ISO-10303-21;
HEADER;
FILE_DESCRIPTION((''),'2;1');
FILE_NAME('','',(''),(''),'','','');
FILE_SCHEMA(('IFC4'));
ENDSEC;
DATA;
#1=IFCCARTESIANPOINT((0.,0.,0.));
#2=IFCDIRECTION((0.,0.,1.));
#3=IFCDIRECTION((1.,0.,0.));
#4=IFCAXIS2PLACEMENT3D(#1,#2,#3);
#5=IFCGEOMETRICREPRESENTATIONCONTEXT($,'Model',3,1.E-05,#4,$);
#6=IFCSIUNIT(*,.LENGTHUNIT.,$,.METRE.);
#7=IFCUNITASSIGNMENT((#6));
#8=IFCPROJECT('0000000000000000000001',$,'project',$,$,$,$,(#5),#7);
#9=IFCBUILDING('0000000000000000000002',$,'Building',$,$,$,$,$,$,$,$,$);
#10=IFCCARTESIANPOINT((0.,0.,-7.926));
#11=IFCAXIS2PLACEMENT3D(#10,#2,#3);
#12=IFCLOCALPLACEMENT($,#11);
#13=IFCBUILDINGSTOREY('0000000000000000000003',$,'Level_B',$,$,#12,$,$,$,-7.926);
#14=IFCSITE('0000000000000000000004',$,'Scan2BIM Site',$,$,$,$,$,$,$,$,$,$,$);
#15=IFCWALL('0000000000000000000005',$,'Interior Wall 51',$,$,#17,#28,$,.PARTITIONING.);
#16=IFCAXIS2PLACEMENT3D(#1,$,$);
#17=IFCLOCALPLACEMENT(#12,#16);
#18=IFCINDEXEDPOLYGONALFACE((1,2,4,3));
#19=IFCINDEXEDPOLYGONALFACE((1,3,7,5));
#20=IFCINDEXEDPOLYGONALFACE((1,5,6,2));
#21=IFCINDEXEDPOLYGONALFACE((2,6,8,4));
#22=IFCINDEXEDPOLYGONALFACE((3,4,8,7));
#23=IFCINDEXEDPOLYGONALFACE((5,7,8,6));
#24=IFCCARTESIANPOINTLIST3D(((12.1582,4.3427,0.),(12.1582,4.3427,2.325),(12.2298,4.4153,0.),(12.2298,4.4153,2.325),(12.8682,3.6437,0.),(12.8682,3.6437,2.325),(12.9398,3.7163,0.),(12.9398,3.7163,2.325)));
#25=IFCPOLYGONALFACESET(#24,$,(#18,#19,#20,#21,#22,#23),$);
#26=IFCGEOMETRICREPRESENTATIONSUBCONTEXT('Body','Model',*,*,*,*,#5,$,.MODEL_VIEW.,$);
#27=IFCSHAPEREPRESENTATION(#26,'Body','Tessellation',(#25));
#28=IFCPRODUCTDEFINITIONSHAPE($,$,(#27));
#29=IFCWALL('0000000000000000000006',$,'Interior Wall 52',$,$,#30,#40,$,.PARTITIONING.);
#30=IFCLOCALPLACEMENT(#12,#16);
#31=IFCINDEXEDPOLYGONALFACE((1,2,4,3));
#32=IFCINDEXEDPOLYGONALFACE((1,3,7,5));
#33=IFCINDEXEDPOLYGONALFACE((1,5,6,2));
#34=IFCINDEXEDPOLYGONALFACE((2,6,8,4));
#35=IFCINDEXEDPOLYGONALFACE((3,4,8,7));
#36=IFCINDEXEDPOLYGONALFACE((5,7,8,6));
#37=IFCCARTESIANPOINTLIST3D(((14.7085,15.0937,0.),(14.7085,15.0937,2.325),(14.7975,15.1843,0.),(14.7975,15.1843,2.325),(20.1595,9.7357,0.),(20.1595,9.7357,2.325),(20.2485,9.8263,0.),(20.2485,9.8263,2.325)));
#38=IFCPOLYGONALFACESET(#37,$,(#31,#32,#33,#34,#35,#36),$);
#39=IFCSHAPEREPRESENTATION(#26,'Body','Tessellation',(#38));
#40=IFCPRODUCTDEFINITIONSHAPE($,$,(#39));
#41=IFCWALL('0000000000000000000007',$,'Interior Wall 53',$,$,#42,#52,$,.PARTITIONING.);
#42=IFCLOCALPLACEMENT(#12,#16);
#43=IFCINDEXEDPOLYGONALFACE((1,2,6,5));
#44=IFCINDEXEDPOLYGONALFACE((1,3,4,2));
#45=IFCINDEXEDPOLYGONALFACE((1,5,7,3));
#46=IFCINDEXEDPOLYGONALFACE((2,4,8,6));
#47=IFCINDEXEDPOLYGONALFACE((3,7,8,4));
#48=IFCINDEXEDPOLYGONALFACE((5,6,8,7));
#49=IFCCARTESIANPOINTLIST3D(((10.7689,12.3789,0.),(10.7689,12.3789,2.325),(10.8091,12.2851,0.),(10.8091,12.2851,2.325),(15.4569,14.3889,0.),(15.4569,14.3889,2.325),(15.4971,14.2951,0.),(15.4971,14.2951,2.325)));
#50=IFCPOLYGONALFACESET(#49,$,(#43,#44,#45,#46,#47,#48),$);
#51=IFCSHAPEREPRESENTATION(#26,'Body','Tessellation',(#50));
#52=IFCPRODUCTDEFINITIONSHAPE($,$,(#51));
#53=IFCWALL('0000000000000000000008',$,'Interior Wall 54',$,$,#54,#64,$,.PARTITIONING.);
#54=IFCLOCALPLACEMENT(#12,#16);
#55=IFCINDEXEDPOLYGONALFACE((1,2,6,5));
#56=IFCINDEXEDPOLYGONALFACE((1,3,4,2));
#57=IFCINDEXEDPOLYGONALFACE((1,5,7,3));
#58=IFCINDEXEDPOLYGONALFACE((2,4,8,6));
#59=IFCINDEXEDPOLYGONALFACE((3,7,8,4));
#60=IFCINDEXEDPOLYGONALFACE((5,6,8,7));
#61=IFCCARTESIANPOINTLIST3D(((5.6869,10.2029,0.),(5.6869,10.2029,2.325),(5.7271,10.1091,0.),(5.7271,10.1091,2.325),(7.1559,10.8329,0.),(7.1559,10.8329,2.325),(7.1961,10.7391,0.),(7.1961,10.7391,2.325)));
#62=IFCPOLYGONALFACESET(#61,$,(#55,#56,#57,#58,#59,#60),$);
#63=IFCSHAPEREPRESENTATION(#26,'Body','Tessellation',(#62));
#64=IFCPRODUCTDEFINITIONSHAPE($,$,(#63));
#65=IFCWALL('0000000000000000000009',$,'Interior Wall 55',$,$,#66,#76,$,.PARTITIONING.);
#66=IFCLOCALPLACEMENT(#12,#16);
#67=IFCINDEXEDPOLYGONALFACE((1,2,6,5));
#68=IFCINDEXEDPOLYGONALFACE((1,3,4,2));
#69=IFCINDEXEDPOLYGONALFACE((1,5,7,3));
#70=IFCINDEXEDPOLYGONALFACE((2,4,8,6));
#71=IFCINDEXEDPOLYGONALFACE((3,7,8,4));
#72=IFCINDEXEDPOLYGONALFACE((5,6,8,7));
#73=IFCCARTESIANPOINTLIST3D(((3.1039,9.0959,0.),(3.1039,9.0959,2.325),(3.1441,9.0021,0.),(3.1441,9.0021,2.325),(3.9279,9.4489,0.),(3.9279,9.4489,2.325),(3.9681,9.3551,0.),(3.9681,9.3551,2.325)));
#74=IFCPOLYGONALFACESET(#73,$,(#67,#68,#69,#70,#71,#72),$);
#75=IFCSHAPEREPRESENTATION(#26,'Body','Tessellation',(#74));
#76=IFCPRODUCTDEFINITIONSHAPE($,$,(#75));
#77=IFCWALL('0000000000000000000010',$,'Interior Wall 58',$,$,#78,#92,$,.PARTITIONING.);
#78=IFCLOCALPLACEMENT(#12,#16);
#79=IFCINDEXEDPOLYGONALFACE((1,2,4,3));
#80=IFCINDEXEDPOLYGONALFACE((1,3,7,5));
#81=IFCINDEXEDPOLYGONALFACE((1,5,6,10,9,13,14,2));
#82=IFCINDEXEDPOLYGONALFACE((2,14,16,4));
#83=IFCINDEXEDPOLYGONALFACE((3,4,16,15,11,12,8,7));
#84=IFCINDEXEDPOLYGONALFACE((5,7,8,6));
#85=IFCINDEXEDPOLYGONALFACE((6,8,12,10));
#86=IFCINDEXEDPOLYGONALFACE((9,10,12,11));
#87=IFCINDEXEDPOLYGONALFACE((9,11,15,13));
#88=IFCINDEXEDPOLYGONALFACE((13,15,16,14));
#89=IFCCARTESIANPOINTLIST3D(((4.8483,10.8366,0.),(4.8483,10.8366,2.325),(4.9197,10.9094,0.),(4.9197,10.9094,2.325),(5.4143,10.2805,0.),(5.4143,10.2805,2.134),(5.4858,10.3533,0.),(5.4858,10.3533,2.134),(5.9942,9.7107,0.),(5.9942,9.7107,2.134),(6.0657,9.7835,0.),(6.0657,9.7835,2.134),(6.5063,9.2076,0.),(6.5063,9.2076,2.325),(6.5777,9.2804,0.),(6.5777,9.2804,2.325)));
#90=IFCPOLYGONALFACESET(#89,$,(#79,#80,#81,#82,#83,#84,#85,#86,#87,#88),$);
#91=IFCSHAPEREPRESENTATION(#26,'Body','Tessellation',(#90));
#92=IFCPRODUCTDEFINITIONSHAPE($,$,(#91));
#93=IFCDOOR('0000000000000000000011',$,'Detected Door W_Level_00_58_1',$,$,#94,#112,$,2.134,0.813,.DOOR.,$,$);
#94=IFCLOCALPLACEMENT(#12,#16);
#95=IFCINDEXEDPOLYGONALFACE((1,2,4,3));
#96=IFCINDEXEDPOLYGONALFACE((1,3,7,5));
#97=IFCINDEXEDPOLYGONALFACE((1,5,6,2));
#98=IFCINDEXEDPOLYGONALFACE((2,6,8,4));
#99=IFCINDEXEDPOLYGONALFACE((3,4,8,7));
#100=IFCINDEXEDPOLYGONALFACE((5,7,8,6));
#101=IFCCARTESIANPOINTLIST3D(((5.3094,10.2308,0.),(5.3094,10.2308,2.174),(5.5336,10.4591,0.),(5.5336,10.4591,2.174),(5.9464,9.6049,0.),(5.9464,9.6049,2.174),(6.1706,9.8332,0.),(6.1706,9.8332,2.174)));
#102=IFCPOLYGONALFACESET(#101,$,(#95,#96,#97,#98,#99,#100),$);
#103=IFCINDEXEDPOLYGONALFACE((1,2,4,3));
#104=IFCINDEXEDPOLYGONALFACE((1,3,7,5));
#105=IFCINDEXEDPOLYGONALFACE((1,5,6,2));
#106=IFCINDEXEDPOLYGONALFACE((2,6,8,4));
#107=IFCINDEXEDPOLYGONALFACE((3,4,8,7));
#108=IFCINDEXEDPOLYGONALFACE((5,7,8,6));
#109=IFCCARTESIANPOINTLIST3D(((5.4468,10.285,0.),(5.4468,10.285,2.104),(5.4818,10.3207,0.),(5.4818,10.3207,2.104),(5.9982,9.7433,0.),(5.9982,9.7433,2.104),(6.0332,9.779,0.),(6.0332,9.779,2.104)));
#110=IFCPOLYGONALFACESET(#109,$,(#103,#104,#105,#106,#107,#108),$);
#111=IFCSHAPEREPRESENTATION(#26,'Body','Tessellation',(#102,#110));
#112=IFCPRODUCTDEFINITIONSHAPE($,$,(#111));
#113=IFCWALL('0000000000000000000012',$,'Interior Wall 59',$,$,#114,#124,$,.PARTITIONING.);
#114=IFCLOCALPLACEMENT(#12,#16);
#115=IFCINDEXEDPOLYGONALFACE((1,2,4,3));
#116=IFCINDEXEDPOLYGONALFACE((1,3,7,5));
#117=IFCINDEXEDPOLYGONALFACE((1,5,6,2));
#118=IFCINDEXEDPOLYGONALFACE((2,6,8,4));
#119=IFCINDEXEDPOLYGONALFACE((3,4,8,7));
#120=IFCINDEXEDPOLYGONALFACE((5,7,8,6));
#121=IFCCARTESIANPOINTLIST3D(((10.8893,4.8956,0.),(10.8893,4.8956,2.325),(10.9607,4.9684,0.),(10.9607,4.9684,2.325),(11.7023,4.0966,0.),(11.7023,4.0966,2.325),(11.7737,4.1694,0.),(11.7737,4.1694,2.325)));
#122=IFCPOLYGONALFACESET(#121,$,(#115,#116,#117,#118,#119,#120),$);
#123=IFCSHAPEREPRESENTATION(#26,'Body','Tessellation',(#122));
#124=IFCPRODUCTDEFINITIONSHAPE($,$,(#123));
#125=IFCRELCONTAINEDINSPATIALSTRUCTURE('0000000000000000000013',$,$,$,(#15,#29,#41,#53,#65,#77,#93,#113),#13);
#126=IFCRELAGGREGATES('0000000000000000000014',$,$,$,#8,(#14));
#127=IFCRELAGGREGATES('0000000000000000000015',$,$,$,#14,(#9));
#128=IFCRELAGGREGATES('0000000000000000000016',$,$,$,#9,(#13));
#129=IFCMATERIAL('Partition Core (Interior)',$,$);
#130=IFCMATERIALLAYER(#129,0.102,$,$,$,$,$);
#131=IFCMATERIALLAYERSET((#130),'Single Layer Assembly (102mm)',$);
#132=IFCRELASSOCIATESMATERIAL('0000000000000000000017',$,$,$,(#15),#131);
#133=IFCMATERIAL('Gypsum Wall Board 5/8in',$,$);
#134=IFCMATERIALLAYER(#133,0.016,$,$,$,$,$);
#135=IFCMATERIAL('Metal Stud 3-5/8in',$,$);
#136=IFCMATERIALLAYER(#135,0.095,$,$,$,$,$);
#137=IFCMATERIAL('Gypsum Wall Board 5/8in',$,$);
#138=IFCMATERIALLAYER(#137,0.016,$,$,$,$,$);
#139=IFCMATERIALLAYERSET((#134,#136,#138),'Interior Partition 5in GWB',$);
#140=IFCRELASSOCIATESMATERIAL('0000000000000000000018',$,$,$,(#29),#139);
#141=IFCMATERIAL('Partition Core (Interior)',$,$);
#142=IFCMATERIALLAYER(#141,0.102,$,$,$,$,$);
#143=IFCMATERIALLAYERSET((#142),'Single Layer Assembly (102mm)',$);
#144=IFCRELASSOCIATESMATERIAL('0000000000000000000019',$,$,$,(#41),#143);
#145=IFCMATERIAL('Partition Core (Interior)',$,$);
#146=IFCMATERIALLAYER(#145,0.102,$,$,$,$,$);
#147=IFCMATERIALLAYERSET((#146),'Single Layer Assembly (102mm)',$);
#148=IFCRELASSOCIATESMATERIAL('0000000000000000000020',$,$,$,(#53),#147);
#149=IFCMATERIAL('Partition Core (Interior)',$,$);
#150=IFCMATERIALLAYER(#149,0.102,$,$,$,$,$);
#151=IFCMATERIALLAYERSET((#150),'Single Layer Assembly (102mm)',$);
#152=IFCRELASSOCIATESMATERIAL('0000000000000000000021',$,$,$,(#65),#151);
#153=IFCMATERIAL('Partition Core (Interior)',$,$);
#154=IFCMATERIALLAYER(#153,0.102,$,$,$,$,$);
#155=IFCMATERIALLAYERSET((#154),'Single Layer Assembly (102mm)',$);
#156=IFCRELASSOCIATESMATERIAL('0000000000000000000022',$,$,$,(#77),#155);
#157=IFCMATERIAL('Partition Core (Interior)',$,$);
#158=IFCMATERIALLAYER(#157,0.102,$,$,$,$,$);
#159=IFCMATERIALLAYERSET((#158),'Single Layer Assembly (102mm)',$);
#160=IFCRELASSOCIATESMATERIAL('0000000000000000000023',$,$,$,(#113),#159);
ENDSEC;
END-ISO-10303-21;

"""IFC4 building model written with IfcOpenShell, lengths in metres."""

from ifc_helpers import new_model, si_unit, frame, origin, origin_with_axes, place, context, subcontext, project, spatial, rectangle, extrude, material, layer, layer_set, element, fill, save


model = new_model("IFC4")

# Units and contexts
model_context = context("Model", 3, precision=1e-05, world=origin_with_axes())
body_context = subcontext(model_context, "Body", "Model", "MODEL_VIEW")
ifc_project = project(units=[si_unit("LENGTHUNIT", "METRE")], contexts=[model_context])

# Site, building, storey
site = spatial("IfcSite", under=ifc_project, Name="Scan2BIM Site")
building = spatial("IfcBuilding", under=site, Name="Building")
storey_placement = place(None, frame((0.0, 0.0, -7.926), z_axis=(0.0, 0.0, 1.0), x_axis=(1.0, 0.0, 0.0)))
storey = spatial("IfcBuildingStorey", under=building, at=storey_placement, Name="Level_B", Elevation=-7.926)

# Walls
ifc_material_1 = material(Name="Partition Core (Interior)")
ifc_layer_1 = layer(ifc_material_1, 0.102)
ifc_layer_set_1 = layer_set([ifc_layer_1], Name="Single Layer Assembly (102mm)")
wall_1_placement = place(storey_placement, frame((12.549, 4.0295, 0.0), z_axis=(0.0, 0.0, 1.0), x_axis=(0.712605, -0.701565, 0.0)))
element("IfcWall", 1, at=wall_1_placement, inside=storey, material=ifc_layer_set_1, Name="Interior Wall 51", PredefinedType="PARTITIONING", context=body_context, shape_type="SweptSolid", body=[
    extrude(rectangle(XDim=0.9963, YDim=0.102), origin(), (0.0, 0.0, 1.0), 2.325),
])
ifc_material_2 = material(Name="Gypsum Wall Board 5/8in")
ifc_layer_2 = layer(ifc_material_2, 0.016)
ifc_material_3 = material(Name="Metal Stud 3-5/8in")
ifc_layer_3 = layer(ifc_material_3, 0.095)
ifc_material_4 = material(Name="Gypsum Wall Board 5/8in")
ifc_layer_4 = layer(ifc_material_4, 0.016)
ifc_layer_set_2 = layer_set([ifc_layer_2, ifc_layer_3, ifc_layer_4], Name="Interior Partition 5in GWB")
wall_2_placement = place(storey_placement, frame((17.4785, 12.46, 0.0), z_axis=(0.0, 0.0, 1.0), x_axis=(-0.713164, 0.700997, 0.0)))
element("IfcWall", 2, at=wall_2_placement, inside=storey, material=ifc_layer_set_2, Name="Interior Wall 52", PredefinedType="PARTITIONING", context=body_context, shape_type="SweptSolid", body=[
    extrude(rectangle(XDim=7.6434, YDim=0.127), origin(), (0.0, 0.0, 1.0), 2.325),
])
ifc_material_5 = material(Name="Partition Core (Interior)")
ifc_layer_5 = layer(ifc_material_5, 0.102)
ifc_layer_set_3 = layer_set([ifc_layer_5], Name="Single Layer Assembly (102mm)")
wall_3_placement = place(storey_placement, frame((13.133, 13.337, 0.0), z_axis=(0.0, 0.0, 1.0), x_axis=(-0.919084, -0.394061, 0.0)))
element("IfcWall", 3, at=wall_3_placement, inside=storey, material=ifc_layer_set_3, Name="Interior Wall 53", PredefinedType="PARTITIONING", context=body_context, shape_type="SweptSolid", body=[
    extrude(rectangle(XDim=5.1007, YDim=0.102), origin(), (0.0, 0.0, 1.0), 2.325),
])
ifc_material_6 = material(Name="Partition Core (Interior)")
ifc_layer_6 = layer(ifc_material_6, 0.102)
ifc_layer_set_4 = layer_set([ifc_layer_6], Name="Single Layer Assembly (102mm)")
wall_4_placement = place(storey_placement, frame((6.4415, 10.471, 0.0), z_axis=(0.0, 0.0, 1.0), x_axis=(-0.919048, -0.394146, 0.0)))
element("IfcWall", 4, at=wall_4_placement, inside=storey, material=ifc_layer_set_4, Name="Interior Wall 54", PredefinedType="PARTITIONING", context=body_context, shape_type="SweptSolid", body=[
    extrude(rectangle(XDim=1.5984, YDim=0.102), origin(), (0.0, 0.0, 1.0), 2.325),
])
ifc_material_7 = material(Name="Partition Core (Interior)")
ifc_layer_7 = layer(ifc_material_7, 0.102)
ifc_layer_set_5 = layer_set([ifc_layer_7], Name="Single Layer Assembly (102mm)")
wall_5_placement = place(storey_placement, frame((3.536, 9.2255, 0.0), z_axis=(0.0, 0.0, 1.0), x_axis=(-0.919203, -0.393785, 0.0)))
element("IfcWall", 5, at=wall_5_placement, inside=storey, material=ifc_layer_set_5, Name="Interior Wall 55", PredefinedType="PARTITIONING", context=body_context, shape_type="SweptSolid", body=[
    extrude(rectangle(XDim=0.8964, YDim=0.102), origin(), (0.0, 0.0, 1.0), 2.325),
])

# Wall, opening, door
ifc_material_8 = material(Name="Partition Core (Interior)")
ifc_layer_8 = layer(ifc_material_8, 0.102)
ifc_layer_set_6 = layer_set([ifc_layer_8], Name="Single Layer Assembly (102mm)")
wall_6_placement = place(storey_placement, frame((5.713, 10.0585, 0.0), z_axis=(0.0, 0.0, 1.0), x_axis=(0.713318, -0.700841, 0.0)))
wall_6 = element("IfcWall", 6, at=wall_6_placement, inside=storey, material=ifc_layer_set_6, Name="Interior Wall 58", PredefinedType="PARTITIONING", context=body_context, shape_type="SweptSolid", body=[
    extrude(rectangle(XDim=2.3244, YDim=0.102), origin(), (0.0, 0.0, 1.0), 2.325),
])
opening_1_placement = place(None, frame((5.74, 10.032, -7.926), z_axis=(0.0, 0.0, 1.0), x_axis=(0.713318, -0.700841, 0.0)))
opening_1 = element("IfcOpeningElement", 7, at=opening_1_placement, cuts=wall_6, PredefinedType="OPENING", context=body_context, shape_type="SweptSolid", body=[
    extrude(rectangle(XDim=0.813, YDim=0.202), origin(), (0.0, 0.0, 1.0), 2.134),
])
door_1_placement = place(opening_1_placement, frame((0.0, 0.0, 0.0), z_axis=(0.0, 0.0, 1.0), x_axis=(1.0, 0.0, 0.0)))
door_1 = element("IfcDoor", 8, at=door_1_placement, inside=storey, Name="Detected Door W_Level_00_58_1", OverallHeight=2.134, OverallWidth=0.813, PredefinedType="DOOR", context=body_context, shape_type="SweptSolid", body=[
    extrude(rectangle(XDim=0.893, YDim=0.32), origin(), (0.0, 0.0, 1.0), 2.174),
    extrude(rectangle(XDim=0.773, YDim=0.05), origin(), (0.0, 0.0, 1.0), 2.104),
])
fill(opening_1, door_1)

# Wall
ifc_material_9 = material(Name="Partition Core (Interior)")
ifc_layer_9 = layer(ifc_material_9, 0.102)
ifc_layer_set_7 = layer_set([ifc_layer_9], Name="Single Layer Assembly (102mm)")
wall_7_placement = place(storey_placement, frame((11.3315, 4.5325, 0.0), z_axis=(0.0, 0.0, 1.0), x_axis=(0.713221, -0.700939, 0.0)))
element("IfcWall", 9, at=wall_7_placement, inside=storey, material=ifc_layer_set_7, Name="Interior Wall 59", PredefinedType="PARTITIONING", context=body_context, shape_type="SweptSolid", body=[
    extrude(rectangle(XDim=1.1399, YDim=0.102), origin(), (0.0, 0.0, 1.0), 2.325),
])

save(model, "model.ifc")
